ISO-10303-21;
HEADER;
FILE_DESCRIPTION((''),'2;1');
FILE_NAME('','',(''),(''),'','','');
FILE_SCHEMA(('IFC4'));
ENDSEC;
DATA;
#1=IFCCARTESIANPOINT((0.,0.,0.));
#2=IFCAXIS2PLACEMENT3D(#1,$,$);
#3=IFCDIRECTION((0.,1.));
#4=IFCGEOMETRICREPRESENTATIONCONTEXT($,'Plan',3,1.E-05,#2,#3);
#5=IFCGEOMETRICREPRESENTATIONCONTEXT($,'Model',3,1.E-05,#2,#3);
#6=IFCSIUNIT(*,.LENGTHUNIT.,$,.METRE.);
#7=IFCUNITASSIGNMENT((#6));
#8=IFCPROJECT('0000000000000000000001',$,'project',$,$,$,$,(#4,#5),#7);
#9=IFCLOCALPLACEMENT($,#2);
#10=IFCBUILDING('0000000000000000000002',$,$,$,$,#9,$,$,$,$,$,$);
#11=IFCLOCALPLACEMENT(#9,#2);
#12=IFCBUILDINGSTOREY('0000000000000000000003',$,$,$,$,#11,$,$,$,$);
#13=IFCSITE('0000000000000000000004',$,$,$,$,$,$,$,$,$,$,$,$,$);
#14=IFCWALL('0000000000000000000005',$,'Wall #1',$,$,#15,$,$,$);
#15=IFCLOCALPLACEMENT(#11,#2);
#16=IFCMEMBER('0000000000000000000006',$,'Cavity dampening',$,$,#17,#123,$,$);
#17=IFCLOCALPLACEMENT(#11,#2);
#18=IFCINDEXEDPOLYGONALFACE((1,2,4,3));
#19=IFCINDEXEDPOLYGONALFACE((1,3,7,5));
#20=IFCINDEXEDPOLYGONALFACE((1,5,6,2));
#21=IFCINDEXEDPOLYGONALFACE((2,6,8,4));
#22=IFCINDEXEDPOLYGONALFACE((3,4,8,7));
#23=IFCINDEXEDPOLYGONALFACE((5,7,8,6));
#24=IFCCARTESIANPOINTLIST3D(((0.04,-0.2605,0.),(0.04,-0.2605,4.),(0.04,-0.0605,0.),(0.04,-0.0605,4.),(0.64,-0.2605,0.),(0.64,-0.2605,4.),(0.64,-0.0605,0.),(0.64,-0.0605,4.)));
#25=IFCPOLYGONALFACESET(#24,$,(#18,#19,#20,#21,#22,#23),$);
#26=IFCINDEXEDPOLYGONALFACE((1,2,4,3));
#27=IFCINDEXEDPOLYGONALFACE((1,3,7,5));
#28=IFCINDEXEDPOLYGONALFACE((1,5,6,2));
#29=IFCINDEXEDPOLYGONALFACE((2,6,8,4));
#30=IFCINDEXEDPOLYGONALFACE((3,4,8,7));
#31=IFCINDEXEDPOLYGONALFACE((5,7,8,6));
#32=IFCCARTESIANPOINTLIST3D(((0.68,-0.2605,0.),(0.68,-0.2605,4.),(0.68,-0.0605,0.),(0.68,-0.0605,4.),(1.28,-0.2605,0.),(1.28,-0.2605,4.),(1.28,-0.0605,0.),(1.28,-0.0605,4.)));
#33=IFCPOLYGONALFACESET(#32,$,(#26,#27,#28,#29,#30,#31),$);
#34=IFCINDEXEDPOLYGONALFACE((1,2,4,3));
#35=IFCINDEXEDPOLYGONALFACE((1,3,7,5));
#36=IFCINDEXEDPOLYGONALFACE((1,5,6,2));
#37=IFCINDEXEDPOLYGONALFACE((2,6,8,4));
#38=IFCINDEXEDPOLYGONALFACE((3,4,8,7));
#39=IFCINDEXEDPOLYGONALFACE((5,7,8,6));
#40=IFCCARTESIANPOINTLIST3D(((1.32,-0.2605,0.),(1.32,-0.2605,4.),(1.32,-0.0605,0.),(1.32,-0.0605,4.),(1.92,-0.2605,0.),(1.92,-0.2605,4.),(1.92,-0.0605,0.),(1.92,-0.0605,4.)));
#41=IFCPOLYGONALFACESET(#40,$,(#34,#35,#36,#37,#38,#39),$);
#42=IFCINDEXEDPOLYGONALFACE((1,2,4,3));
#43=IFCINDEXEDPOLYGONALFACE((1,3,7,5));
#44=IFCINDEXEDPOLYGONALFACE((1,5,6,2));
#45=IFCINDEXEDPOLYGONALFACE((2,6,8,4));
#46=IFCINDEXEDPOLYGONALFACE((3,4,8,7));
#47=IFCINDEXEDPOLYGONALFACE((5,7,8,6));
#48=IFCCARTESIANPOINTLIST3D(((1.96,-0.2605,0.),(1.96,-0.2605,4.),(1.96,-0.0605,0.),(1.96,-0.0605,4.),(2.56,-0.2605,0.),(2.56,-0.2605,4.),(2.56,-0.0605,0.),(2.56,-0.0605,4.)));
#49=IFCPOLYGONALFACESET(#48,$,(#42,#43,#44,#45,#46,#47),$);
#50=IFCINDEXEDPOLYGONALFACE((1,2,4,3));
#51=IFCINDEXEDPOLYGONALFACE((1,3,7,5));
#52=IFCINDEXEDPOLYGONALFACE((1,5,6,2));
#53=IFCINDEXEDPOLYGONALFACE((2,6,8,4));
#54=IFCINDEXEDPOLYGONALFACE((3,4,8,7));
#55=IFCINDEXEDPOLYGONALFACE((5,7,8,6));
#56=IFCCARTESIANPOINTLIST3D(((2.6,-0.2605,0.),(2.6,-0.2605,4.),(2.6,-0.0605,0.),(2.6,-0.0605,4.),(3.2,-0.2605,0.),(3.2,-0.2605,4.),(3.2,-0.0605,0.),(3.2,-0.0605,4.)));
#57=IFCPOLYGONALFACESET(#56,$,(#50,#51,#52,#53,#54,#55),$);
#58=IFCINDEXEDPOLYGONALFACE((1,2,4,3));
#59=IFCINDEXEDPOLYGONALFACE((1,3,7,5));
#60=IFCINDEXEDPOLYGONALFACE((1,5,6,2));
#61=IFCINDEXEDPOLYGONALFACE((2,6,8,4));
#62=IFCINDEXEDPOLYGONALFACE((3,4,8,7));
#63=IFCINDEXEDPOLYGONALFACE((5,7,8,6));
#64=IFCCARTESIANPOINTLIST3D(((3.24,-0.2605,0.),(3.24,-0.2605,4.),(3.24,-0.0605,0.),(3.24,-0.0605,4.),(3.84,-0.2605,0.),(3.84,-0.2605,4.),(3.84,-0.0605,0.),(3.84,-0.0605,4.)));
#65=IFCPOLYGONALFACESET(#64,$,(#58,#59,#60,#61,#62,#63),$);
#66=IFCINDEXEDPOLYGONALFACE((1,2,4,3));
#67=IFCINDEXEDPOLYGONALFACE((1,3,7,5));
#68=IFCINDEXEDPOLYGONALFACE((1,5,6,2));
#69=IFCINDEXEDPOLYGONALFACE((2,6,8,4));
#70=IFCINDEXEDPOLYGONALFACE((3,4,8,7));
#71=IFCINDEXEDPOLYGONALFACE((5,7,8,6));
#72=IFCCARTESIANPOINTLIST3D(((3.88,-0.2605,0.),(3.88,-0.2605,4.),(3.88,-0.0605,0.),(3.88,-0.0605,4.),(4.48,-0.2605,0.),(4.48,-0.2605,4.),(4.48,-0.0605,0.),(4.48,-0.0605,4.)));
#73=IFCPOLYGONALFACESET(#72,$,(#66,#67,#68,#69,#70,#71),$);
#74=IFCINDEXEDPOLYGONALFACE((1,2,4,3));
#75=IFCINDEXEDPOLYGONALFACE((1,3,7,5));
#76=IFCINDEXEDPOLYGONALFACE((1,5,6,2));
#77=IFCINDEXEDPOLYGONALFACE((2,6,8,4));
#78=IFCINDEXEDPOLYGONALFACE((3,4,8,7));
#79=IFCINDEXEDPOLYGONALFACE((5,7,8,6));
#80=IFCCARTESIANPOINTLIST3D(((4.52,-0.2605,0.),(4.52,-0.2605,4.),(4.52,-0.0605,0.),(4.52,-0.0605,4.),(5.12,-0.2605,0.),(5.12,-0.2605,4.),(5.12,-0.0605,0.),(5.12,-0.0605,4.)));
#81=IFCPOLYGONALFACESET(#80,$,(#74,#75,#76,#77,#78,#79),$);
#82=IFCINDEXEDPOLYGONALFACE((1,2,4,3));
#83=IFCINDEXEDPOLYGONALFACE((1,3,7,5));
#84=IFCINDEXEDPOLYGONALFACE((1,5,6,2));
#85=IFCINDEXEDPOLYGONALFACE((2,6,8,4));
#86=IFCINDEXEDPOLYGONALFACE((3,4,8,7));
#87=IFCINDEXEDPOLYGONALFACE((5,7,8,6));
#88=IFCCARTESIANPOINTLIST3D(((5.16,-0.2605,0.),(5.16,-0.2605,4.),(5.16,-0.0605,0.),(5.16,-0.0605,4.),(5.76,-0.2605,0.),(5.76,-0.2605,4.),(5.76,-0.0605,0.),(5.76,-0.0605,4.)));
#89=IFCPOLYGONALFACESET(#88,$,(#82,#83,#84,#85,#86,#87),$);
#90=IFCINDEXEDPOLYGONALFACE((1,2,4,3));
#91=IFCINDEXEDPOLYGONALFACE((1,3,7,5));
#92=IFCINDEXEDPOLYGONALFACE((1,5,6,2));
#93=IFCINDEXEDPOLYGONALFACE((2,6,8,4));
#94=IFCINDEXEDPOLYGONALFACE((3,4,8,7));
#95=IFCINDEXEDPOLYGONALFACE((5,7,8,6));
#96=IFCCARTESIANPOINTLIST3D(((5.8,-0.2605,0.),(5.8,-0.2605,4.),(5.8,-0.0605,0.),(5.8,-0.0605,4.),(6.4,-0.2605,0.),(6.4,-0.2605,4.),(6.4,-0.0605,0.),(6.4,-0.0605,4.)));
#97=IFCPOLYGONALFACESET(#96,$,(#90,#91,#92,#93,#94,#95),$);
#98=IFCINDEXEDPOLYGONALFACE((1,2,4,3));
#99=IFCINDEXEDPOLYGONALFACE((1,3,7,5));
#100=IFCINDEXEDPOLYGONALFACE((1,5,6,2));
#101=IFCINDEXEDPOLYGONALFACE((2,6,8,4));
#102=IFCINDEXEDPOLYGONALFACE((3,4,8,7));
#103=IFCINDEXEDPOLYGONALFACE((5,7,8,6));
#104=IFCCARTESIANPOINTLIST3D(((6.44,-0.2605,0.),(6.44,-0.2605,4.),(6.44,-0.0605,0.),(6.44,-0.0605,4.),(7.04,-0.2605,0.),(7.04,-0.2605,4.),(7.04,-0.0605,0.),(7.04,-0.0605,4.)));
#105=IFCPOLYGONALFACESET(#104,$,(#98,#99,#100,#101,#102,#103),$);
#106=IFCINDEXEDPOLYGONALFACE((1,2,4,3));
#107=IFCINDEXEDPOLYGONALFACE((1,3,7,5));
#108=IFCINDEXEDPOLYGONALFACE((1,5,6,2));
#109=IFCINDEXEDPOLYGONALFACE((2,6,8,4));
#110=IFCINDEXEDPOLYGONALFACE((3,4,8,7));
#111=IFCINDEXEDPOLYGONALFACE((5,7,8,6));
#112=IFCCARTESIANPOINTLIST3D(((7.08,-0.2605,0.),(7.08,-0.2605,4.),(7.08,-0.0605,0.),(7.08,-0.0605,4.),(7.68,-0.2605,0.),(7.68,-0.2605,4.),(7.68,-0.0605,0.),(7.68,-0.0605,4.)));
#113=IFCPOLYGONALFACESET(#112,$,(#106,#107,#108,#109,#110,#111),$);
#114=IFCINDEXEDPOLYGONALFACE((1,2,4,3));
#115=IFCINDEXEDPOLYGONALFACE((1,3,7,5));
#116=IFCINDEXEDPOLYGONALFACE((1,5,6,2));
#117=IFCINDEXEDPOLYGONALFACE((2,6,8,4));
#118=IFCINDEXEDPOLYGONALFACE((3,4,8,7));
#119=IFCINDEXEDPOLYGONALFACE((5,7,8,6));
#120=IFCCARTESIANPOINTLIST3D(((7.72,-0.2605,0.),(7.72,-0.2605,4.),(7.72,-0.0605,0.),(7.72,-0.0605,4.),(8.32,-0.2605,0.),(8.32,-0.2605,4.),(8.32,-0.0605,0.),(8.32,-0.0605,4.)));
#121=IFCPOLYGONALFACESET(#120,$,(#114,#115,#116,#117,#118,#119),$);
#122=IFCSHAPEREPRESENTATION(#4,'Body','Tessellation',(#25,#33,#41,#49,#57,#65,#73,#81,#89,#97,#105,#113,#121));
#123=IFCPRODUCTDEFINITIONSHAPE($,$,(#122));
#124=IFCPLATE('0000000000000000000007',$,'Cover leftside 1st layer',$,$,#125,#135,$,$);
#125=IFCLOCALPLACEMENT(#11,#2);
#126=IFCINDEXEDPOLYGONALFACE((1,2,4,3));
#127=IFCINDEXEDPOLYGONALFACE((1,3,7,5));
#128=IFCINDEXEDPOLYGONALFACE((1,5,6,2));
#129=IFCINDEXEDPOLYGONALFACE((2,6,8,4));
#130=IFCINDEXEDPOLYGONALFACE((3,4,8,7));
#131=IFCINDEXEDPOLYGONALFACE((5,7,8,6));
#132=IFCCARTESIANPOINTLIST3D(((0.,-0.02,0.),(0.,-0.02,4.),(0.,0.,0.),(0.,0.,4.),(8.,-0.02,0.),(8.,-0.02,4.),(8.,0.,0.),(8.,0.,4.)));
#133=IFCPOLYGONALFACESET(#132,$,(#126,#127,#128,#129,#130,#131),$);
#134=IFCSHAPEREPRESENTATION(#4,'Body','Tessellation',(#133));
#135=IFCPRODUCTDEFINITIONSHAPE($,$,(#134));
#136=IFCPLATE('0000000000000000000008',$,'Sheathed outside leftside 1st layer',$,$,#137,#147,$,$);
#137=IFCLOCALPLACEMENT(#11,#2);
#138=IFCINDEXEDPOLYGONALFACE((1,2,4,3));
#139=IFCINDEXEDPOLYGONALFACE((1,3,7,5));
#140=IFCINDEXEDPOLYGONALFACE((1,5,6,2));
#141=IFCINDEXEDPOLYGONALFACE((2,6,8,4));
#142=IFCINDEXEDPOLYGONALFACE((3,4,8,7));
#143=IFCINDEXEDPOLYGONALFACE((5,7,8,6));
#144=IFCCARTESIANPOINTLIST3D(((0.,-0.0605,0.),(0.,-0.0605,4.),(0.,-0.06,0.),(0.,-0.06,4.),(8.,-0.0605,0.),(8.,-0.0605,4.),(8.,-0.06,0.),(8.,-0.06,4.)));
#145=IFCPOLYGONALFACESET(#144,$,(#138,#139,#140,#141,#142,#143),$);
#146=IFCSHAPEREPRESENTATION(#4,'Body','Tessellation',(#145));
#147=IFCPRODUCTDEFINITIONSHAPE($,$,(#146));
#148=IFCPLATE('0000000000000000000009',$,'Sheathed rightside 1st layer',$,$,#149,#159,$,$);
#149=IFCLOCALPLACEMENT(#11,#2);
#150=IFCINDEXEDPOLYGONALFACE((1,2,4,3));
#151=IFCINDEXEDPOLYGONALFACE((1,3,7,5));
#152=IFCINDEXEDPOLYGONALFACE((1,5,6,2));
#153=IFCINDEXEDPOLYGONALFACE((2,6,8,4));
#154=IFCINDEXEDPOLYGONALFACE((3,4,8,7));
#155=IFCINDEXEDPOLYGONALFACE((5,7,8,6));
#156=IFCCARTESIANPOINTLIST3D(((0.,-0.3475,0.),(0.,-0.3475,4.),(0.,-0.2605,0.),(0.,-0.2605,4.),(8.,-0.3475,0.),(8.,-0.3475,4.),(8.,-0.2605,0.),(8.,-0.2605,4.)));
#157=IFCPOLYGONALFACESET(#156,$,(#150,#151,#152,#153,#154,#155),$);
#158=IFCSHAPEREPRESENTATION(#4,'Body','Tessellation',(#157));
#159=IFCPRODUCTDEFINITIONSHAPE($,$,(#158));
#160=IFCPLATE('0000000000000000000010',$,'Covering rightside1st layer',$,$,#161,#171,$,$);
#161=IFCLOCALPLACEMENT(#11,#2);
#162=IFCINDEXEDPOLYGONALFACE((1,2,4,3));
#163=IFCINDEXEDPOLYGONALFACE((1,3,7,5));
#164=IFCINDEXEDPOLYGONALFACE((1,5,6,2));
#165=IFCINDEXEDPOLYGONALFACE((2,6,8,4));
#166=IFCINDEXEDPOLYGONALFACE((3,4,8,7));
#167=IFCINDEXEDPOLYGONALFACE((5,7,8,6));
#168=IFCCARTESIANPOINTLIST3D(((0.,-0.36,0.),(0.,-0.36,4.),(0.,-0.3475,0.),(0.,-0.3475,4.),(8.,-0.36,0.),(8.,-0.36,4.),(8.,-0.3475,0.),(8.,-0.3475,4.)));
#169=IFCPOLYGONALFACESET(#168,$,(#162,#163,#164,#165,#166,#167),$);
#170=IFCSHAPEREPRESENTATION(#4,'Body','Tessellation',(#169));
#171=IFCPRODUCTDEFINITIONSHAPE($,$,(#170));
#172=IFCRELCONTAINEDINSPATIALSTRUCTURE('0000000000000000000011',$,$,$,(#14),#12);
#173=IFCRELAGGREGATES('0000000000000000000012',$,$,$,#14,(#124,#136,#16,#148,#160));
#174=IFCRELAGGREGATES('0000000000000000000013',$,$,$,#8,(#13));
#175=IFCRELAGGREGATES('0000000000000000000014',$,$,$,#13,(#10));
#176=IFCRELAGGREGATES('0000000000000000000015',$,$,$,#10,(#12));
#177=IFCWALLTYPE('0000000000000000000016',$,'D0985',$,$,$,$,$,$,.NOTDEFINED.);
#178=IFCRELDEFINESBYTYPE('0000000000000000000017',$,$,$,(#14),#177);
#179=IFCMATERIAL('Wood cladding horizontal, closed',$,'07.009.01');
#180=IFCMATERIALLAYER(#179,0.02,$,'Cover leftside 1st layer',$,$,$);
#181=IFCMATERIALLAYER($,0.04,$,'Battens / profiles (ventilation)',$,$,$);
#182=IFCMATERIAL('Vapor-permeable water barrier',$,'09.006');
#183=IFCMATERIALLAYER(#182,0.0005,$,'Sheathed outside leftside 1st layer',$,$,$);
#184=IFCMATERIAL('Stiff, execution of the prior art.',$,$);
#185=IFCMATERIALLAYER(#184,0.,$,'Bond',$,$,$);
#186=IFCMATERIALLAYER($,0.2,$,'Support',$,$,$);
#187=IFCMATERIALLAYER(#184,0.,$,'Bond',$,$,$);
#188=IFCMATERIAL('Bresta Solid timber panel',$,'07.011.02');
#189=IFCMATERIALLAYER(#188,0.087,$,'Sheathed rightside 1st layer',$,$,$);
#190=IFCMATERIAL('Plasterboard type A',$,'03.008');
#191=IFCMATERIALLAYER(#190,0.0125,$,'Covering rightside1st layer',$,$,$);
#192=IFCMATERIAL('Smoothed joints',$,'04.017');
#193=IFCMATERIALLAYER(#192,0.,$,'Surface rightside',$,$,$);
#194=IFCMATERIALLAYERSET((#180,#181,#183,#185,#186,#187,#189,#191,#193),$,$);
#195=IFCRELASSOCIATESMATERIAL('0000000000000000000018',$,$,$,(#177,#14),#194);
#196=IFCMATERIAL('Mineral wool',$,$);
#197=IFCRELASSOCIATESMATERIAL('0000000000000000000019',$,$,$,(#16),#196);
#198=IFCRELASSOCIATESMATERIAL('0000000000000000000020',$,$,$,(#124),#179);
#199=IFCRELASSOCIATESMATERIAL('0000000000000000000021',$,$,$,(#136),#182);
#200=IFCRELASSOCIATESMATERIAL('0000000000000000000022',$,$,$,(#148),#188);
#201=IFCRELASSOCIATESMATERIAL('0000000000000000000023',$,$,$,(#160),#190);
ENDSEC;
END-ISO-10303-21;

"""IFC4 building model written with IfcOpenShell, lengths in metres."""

from ifc_helpers import new_model, si_unit, direction, frame, frame_2d, origin, origin_with_axes, place, context, project, spatial, rectangle, extrude, material, layer, layer_set, type_object, element, aggregate, save


model = new_model("IFC4")

# Units and contexts
plan_context = context("Plan", 3, precision=1e-05, world=origin(), true_north=direction((0.0, 1.0)))
model_context = context("Model", 3, precision=1e-05, world=origin(), true_north=direction((0.0, 1.0)))
ifc_project = project(units=[si_unit("LENGTHUNIT", "METRE")], contexts=[plan_context, model_context])

# Site, building, storey
site = spatial("IfcSite", under=ifc_project)
building_placement = place(None, origin())
building = spatial("IfcBuilding", under=site, at=building_placement)
storey_placement = place(building_placement, origin())
storey = spatial("IfcBuildingStorey", under=building, at=storey_placement)

# Wall, member, plates
ifc_material_1 = material(Name="Wood cladding horizontal, closed", Category="07.009.01")
ifc_layer_1 = layer(ifc_material_1, 0.02, Name="Cover leftside 1st layer")
ifc_layer_2 = layer(None, 0.04, Name="Battens / profiles (ventilation)")
ifc_material_2 = material(Name="Vapor-permeable water barrier", Category="09.006")
ifc_layer_3 = layer(ifc_material_2, 0.0005, Name="Sheathed outside leftside 1st layer")
ifc_material_3 = material(Name="Stiff, execution of the prior art.")
ifc_layer_4 = layer(ifc_material_3, 0.0, Name="Bond")
ifc_layer_5 = layer(None, 0.2, Name="Support")
ifc_layer_6 = layer(ifc_material_3, 0.0, Name="Bond")
ifc_material_4 = material(Name="Bresta Solid timber panel", Category="07.011.02")
ifc_layer_7 = layer(ifc_material_4, 0.087, Name="Sheathed rightside 1st layer")
ifc_material_5 = material(Name="Plasterboard type A", Category="03.008")
ifc_layer_8 = layer(ifc_material_5, 0.0125, Name="Covering rightside1st layer")
ifc_material_6 = material(Name="Smoothed joints", Category="04.017")
ifc_layer_9 = layer(ifc_material_6, 0.0, Name="Surface rightside")
ifc_layer_set = layer_set([ifc_layer_1, ifc_layer_2, ifc_layer_3, ifc_layer_4, ifc_layer_5, ifc_layer_6, ifc_layer_7, ifc_layer_8, ifc_layer_9])
wall_type = type_object("IfcWallType", Name="D0985", PredefinedType="NOTDEFINED", material=ifc_layer_set)
wall_placement = place(None, frame((0.0, 0.0, 0.0), z_axis=(0.0, -1.0, 0.0), x_axis=(1.0, 0.0, 0.0)))
wall = element("IfcWall", 1, at=wall_placement, inside=storey, type_object=wall_type, material=ifc_layer_set, Name="Wall #1")
ifc_material_7 = material(Name="Mineral wool")
member_1_placement = place(wall_placement, origin())
member_1 = element("IfcMember", 2, at=member_1_placement, material=ifc_material_7, Name="Cavity dampening", context=plan_context, shape_type="SweptSolid", body=[
    extrude(rectangle(XDim=0.6, YDim=0.2, at=frame_2d((0.3, 0.1), x_axis=(1.0, 0.0))), frame((0.04, 4.0, 0.0605), z_axis=(0.0, -1.0, 0.0), x_axis=(1.0, 0.0, 0.0)), (0.0, 0.0, 1.0), 4.0),
    extrude(rectangle(XDim=0.6, YDim=0.2, at=frame_2d((0.3, 0.1), x_axis=(1.0, 0.0))), frame((0.68, 4.0, 0.0605), z_axis=(0.0, -1.0, 0.0), x_axis=(1.0, 0.0, 0.0)), (0.0, 0.0, 1.0), 4.0),
    extrude(rectangle(XDim=0.6, YDim=0.2, at=frame_2d((0.3, 0.1), x_axis=(1.0, 0.0))), frame((1.32, 4.0, 0.0605), z_axis=(0.0, -1.0, 0.0), x_axis=(1.0, 0.0, 0.0)), (0.0, 0.0, 1.0), 4.0),
    extrude(rectangle(XDim=0.6, YDim=0.2, at=frame_2d((0.3, 0.1), x_axis=(1.0, 0.0))), frame((1.96, 4.0, 0.0605), z_axis=(0.0, -1.0, 0.0), x_axis=(1.0, 0.0, 0.0)), (0.0, 0.0, 1.0), 4.0),
    extrude(rectangle(XDim=0.6, YDim=0.2, at=frame_2d((0.3, 0.1), x_axis=(1.0, 0.0))), frame((2.6, 4.0, 0.0605), z_axis=(0.0, -1.0, 0.0), x_axis=(1.0, 0.0, 0.0)), (0.0, 0.0, 1.0), 4.0),
    extrude(rectangle(XDim=0.6, YDim=0.2, at=frame_2d((0.3, 0.1), x_axis=(1.0, 0.0))), frame((3.24, 4.0, 0.0605), z_axis=(0.0, -1.0, 0.0), x_axis=(1.0, 0.0, 0.0)), (0.0, 0.0, 1.0), 4.0),
    extrude(rectangle(XDim=0.6, YDim=0.2, at=frame_2d((0.3, 0.1), x_axis=(1.0, 0.0))), frame((3.88, 4.0, 0.0605), z_axis=(0.0, -1.0, 0.0), x_axis=(1.0, 0.0, 0.0)), (0.0, 0.0, 1.0), 4.0),
    extrude(rectangle(XDim=0.6, YDim=0.2, at=frame_2d((0.3, 0.1), x_axis=(1.0, 0.0))), frame((4.52, 4.0, 0.0605), z_axis=(0.0, -1.0, 0.0), x_axis=(1.0, 0.0, 0.0)), (0.0, 0.0, 1.0), 4.0),
    extrude(rectangle(XDim=0.6, YDim=0.2, at=frame_2d((0.3, 0.1), x_axis=(1.0, 0.0))), frame((5.16, 4.0, 0.0605), z_axis=(0.0, -1.0, 0.0), x_axis=(1.0, 0.0, 0.0)), (0.0, 0.0, 1.0), 4.0),
    extrude(rectangle(XDim=0.6, YDim=0.2, at=frame_2d((0.3, 0.1), x_axis=(1.0, 0.0))), frame((5.8, 4.0, 0.0605), z_axis=(0.0, -1.0, 0.0), x_axis=(1.0, 0.0, 0.0)), (0.0, 0.0, 1.0), 4.0),
    extrude(rectangle(XDim=0.6, YDim=0.2, at=frame_2d((0.3, 0.1), x_axis=(1.0, 0.0))), frame((6.44, 4.0, 0.0605), z_axis=(0.0, -1.0, 0.0), x_axis=(1.0, 0.0, 0.0)), (0.0, 0.0, 1.0), 4.0),
    extrude(rectangle(XDim=0.6, YDim=0.2, at=frame_2d((0.3, 0.1), x_axis=(1.0, 0.0))), frame((7.08, 4.0, 0.0605), z_axis=(0.0, -1.0, 0.0), x_axis=(1.0, 0.0, 0.0)), (0.0, 0.0, 1.0), 4.0),
    extrude(rectangle(XDim=0.6, YDim=0.2, at=frame_2d((0.3, 0.1), x_axis=(1.0, 0.0))), frame((7.72, 4.0, 0.0605), z_axis=(0.0, -1.0, 0.0), x_axis=(1.0, 0.0, 0.0)), (0.0, 0.0, 1.0), 4.0),
])
plate_1_placement = place(wall_placement, origin())
plate_1 = element("IfcPlate", 3, at=plate_1_placement, material=ifc_material_1, Name="Cover leftside 1st layer", context=plan_context, shape_type="SweptSolid", body=[
    extrude(rectangle(XDim=8.0, YDim=4.0, at=frame_2d((4.0, 2.0), x_axis=(1.0, 0.0))), origin_with_axes(), (0.0, 0.0, 1.0), 0.02),
])
plate_2_placement = place(wall_placement, origin())
plate_2 = element("IfcPlate", 4, at=plate_2_placement, material=ifc_material_2, Name="Sheathed outside leftside 1st layer", context=plan_context, shape_type="SweptSolid", body=[
    extrude(rectangle(XDim=8.0, YDim=4.0, at=frame_2d((4.0, 2.0), x_axis=(1.0, 0.0))), frame((0.0, 0.0, 0.06), z_axis=(0.0, 0.0, 1.0), x_axis=(1.0, 0.0, 0.0)), (0.0, 0.0, 1.0), 0.0005),
])
plate_3_placement = place(wall_placement, origin())
plate_3 = element("IfcPlate", 5, at=plate_3_placement, material=ifc_material_4, Name="Sheathed rightside 1st layer", context=plan_context, shape_type="SweptSolid", body=[
    extrude(rectangle(XDim=8.0, YDim=4.0, at=frame_2d((4.0, 2.0), x_axis=(1.0, 0.0))), frame((0.0, 0.0, 0.2605), z_axis=(0.0, 0.0, 1.0), x_axis=(1.0, 0.0, 0.0)), (0.0, 0.0, 1.0), 0.087),
])
plate_4_placement = place(wall_placement, origin())
plate_4 = element("IfcPlate", 6, at=plate_4_placement, material=ifc_material_5, Name="Covering rightside1st layer", context=plan_context, shape_type="SweptSolid", body=[
    extrude(rectangle(XDim=8.0, YDim=4.0, at=frame_2d((4.0, 2.0), x_axis=(1.0, 0.0))), frame((0.0, 0.0, 0.3475), z_axis=(0.0, 0.0, 1.0), x_axis=(1.0, 0.0, 0.0)), (0.0, 0.0, 1.0), 0.0125),
])
aggregate(wall, [plate_1, plate_2, member_1, plate_3, plate_4])

save(model, "model.ifc")
